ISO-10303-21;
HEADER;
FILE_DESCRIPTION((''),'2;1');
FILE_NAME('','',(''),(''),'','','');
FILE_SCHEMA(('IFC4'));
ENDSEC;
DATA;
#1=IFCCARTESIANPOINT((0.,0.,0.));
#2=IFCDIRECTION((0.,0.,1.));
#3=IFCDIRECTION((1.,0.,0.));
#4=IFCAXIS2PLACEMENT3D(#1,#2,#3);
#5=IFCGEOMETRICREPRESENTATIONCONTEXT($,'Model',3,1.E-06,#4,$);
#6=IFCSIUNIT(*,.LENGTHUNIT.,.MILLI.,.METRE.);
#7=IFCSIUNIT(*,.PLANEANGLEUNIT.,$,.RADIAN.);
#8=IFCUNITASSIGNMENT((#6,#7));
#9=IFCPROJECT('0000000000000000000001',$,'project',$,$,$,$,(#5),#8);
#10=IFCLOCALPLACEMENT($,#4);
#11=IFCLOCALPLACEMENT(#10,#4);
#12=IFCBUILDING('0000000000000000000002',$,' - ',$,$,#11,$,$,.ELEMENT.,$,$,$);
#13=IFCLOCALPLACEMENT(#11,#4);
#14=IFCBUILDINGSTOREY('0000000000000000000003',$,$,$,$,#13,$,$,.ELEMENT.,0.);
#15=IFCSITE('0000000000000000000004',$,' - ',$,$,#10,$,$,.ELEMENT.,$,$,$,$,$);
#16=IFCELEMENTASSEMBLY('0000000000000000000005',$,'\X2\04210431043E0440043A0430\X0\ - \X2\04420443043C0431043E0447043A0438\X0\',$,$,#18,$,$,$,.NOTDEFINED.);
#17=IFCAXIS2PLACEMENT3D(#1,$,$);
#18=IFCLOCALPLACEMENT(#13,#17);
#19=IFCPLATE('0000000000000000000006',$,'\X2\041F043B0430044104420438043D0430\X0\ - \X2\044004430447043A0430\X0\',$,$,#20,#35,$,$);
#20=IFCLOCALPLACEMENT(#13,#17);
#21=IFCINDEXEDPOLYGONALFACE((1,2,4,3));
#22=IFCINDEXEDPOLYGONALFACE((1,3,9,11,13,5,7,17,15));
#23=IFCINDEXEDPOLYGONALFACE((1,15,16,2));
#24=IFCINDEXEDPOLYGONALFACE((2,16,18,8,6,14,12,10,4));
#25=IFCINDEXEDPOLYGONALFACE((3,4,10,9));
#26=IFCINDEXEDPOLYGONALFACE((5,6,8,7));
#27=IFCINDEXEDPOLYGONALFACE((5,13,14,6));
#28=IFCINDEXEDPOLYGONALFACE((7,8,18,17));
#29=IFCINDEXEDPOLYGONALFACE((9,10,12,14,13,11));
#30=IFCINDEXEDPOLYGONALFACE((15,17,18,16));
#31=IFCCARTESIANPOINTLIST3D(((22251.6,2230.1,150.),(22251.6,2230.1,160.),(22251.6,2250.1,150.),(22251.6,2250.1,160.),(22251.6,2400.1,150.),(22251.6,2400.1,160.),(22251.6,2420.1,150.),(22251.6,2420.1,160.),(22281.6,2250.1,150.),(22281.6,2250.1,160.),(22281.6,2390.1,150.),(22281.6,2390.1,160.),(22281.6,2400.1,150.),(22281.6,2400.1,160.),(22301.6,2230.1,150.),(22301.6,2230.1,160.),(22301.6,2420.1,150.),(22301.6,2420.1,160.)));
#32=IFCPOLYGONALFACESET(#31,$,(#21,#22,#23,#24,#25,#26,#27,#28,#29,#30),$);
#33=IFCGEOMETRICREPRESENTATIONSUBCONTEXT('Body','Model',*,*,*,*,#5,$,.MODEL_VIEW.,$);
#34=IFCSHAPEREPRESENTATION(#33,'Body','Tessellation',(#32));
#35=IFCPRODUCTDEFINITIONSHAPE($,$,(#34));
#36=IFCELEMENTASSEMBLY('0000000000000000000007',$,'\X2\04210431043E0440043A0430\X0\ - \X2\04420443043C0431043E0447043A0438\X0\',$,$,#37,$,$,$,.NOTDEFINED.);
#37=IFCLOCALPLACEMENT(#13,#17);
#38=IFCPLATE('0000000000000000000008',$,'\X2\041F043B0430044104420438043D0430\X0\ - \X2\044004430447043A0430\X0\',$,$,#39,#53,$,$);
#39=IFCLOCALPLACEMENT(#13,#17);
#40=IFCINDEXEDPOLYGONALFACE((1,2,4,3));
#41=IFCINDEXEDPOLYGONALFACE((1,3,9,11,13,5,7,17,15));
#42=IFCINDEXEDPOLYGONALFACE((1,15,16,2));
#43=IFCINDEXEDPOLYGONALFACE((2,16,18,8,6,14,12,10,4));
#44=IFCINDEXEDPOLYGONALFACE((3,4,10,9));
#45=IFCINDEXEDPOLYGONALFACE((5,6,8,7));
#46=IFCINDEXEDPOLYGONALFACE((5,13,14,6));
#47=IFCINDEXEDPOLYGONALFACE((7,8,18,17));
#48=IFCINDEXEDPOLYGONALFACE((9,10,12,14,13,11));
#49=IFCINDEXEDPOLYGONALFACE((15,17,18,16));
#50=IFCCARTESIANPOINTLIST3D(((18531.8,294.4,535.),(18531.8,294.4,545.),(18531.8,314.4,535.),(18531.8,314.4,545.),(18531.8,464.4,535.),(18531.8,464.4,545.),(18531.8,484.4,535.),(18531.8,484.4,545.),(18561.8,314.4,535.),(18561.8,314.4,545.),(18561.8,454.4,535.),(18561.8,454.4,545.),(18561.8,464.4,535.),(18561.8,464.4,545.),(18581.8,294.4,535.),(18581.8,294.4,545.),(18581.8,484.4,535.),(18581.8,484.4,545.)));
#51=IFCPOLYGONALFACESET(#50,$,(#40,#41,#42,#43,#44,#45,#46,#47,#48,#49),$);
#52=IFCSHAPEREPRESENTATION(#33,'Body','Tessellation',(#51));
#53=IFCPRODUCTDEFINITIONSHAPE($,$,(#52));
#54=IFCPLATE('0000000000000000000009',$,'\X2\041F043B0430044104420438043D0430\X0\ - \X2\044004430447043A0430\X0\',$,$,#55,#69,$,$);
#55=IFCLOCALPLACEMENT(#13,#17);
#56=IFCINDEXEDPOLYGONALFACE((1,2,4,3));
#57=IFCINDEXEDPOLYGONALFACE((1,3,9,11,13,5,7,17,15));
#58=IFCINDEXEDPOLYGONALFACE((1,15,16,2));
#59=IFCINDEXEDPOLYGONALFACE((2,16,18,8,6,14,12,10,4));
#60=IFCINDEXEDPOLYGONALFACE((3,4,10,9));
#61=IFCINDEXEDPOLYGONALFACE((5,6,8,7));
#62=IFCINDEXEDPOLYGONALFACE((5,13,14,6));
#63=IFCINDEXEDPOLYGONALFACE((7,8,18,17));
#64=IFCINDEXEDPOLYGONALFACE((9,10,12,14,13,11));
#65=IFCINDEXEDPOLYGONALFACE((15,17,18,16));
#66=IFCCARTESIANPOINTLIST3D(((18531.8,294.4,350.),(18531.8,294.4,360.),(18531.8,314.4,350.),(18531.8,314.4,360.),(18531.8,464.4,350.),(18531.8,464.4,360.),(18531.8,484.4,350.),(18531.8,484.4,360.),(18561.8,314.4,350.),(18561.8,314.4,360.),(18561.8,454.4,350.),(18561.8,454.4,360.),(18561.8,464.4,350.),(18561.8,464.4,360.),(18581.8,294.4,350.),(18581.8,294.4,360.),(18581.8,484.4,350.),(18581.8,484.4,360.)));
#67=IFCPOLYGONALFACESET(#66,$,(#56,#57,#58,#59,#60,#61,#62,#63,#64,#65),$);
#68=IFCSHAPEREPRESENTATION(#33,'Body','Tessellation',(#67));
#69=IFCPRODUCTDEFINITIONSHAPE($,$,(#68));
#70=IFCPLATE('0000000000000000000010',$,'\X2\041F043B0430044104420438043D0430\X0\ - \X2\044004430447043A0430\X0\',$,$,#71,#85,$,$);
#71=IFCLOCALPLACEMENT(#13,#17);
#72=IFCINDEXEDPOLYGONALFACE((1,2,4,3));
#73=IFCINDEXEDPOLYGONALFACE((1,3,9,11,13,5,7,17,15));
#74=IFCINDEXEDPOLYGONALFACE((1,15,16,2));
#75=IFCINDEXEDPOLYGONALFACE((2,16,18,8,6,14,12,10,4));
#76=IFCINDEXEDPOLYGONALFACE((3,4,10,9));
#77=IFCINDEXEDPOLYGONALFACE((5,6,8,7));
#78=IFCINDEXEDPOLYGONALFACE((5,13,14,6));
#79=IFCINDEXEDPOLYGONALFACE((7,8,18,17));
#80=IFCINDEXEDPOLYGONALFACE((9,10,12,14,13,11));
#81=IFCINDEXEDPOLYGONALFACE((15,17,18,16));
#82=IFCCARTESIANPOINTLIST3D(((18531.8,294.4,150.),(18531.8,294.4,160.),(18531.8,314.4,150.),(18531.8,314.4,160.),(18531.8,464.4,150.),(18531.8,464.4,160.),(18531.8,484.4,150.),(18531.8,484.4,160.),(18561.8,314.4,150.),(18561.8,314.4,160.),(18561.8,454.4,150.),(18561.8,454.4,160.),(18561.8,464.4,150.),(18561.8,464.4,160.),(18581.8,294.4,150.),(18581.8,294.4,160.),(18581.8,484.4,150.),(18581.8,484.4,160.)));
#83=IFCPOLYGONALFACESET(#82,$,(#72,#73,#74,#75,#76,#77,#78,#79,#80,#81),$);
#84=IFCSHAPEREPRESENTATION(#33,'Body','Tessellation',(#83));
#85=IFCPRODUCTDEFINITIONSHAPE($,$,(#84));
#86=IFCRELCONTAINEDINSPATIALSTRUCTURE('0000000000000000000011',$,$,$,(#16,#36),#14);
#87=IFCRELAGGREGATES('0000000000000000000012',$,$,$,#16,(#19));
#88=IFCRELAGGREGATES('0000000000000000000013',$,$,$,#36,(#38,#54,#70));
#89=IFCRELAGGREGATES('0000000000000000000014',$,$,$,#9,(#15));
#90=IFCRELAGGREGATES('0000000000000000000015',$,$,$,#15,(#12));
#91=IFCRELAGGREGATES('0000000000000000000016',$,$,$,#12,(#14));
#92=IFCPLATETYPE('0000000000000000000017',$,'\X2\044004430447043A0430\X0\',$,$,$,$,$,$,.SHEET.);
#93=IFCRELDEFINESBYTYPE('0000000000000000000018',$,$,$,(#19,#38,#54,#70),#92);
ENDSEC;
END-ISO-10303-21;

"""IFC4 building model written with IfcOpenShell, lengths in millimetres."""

from ifc_helpers import new_model, si_unit, frame, origin_with_axes, place, context, subcontext, project, spatial, line, indexed_curve, outline, extrude, source, transform, mapped, type_object, element, aggregate, save


model = new_model("IFC4")

# Units and contexts
model_context = context("Model", 3, precision=1e-06, world=origin_with_axes())
body_context = subcontext(model_context, "Body", "Model", "MODEL_VIEW")
ifc_project = project(units=[si_unit("LENGTHUNIT", "METRE", prefix="MILLI"), si_unit("PLANEANGLEUNIT", "RADIAN")], contexts=[model_context])

# Site, building, storey
site_placement = place(None, origin_with_axes())
site = spatial("IfcSite", under=ifc_project, at=site_placement, Name=" - ", CompositionType="ELEMENT")
building_placement = place(site_placement, origin_with_axes())
building = spatial("IfcBuilding", under=site, at=building_placement, Name=" - ", CompositionType="ELEMENT")
storey_placement = place(building_placement, origin_with_axes())
storey = spatial("IfcBuildingStorey", under=building, at=storey_placement, CompositionType="ELEMENT", Elevation=0.0)

# Shared definitions
plate_type = type_object("IfcPlateType", Name="ручка", PredefinedType="SHEET")
shared_shape = source(origin_with_axes(), body_context, "Body", "SweptSolid", [
    extrude(outline(indexed_curve([(-95.0, -25.0), (-75.0, -25.0), (-75.0, 5.0), (-65.0, 5.0), (75.0, 5.0), (75.0, -25.0), (95.0, -25.0), (95.0, 25.0), (-95.0, 25.0)], segments=[line(1, 2), line(2, 3), line(3, 4), line(4, 5), line(5, 6), line(6, 7), line(7, 8), line(8, 9), line(9, 1)])), origin_with_axes(), (0.0, 0.0, 1.0), 10.0),
])

# Element assemblies, plates
assembly_1_placement = place(storey_placement, frame((22251.6, 2125.1, 0.0), z_axis=(0.0, 0.0, 1.0), x_axis=(0.0, 1.0, 0.0)))
assembly_1 = element("IfcElementAssembly", 1, at=assembly_1_placement, inside=storey, Name="Сборка - тумбочки", PredefinedType="NOTDEFINED")
plate_1_placement = place(assembly_1_placement, frame((200.0, -25.0, 150.0), z_axis=(0.0, 0.0, 1.0), x_axis=(-1.0, 0.0, 0.0)))
plate_1 = element("IfcPlate", 2, at=plate_1_placement, type_object=plate_type, Name="Пластина - ручка", context=body_context, shape_type="MappedRepresentation", body=[
    mapped(shared_shape, transform((0.0, 0.0, 0.0), x_axis=(1.0, 0.0, 0.0), y_axis=(0.0, 1.0, 0.0), z_axis=(0.0, 0.0, 1.0), scale=1.0)),
])
aggregate(assembly_1, [plate_1])
assembly_2_placement = place(storey_placement, frame((18531.8, 189.4, 0.0), z_axis=(0.0, 0.0, 1.0), x_axis=(0.0, 1.0, 0.0)))
assembly_2 = element("IfcElementAssembly", 3, at=assembly_2_placement, inside=storey, Name="Сборка - тумбочки", PredefinedType="NOTDEFINED")
plate_2_placement = place(assembly_2_placement, frame((200.0, -25.0, 535.0), z_axis=(0.0, 0.0, 1.0), x_axis=(-1.0, 0.0, 0.0)))
plate_2 = element("IfcPlate", 4, at=plate_2_placement, type_object=plate_type, Name="Пластина - ручка", context=body_context, shape_type="MappedRepresentation", body=[
    mapped(shared_shape, transform((0.0, 0.0, 0.0), x_axis=(1.0, 0.0, 0.0), y_axis=(0.0, 1.0, 0.0), z_axis=(0.0, 0.0, 1.0), scale=1.0)),
])
plate_3_placement = place(assembly_2_placement, frame((200.0, -25.0, 350.0), z_axis=(0.0, 0.0, 1.0), x_axis=(-1.0, 0.0, 0.0)))
plate_3 = element("IfcPlate", 5, at=plate_3_placement, type_object=plate_type, Name="Пластина - ручка", context=body_context, shape_type="MappedRepresentation", body=[
    mapped(shared_shape, transform((0.0, 0.0, 0.0), x_axis=(1.0, 0.0, 0.0), y_axis=(0.0, 1.0, 0.0), z_axis=(0.0, 0.0, 1.0), scale=1.0)),
])
plate_4_placement = place(assembly_2_placement, frame((200.0, -25.0, 150.0), z_axis=(0.0, 0.0, 1.0), x_axis=(-1.0, 0.0, 0.0)))
plate_4 = element("IfcPlate", 6, at=plate_4_placement, type_object=plate_type, Name="Пластина - ручка", context=body_context, shape_type="MappedRepresentation", body=[
    mapped(shared_shape, transform((0.0, 0.0, 0.0), x_axis=(1.0, 0.0, 0.0), y_axis=(0.0, 1.0, 0.0), z_axis=(0.0, 0.0, 1.0), scale=1.0)),
])
aggregate(assembly_2, [plate_2, plate_3, plate_4])

save(model, "model.ifc")
